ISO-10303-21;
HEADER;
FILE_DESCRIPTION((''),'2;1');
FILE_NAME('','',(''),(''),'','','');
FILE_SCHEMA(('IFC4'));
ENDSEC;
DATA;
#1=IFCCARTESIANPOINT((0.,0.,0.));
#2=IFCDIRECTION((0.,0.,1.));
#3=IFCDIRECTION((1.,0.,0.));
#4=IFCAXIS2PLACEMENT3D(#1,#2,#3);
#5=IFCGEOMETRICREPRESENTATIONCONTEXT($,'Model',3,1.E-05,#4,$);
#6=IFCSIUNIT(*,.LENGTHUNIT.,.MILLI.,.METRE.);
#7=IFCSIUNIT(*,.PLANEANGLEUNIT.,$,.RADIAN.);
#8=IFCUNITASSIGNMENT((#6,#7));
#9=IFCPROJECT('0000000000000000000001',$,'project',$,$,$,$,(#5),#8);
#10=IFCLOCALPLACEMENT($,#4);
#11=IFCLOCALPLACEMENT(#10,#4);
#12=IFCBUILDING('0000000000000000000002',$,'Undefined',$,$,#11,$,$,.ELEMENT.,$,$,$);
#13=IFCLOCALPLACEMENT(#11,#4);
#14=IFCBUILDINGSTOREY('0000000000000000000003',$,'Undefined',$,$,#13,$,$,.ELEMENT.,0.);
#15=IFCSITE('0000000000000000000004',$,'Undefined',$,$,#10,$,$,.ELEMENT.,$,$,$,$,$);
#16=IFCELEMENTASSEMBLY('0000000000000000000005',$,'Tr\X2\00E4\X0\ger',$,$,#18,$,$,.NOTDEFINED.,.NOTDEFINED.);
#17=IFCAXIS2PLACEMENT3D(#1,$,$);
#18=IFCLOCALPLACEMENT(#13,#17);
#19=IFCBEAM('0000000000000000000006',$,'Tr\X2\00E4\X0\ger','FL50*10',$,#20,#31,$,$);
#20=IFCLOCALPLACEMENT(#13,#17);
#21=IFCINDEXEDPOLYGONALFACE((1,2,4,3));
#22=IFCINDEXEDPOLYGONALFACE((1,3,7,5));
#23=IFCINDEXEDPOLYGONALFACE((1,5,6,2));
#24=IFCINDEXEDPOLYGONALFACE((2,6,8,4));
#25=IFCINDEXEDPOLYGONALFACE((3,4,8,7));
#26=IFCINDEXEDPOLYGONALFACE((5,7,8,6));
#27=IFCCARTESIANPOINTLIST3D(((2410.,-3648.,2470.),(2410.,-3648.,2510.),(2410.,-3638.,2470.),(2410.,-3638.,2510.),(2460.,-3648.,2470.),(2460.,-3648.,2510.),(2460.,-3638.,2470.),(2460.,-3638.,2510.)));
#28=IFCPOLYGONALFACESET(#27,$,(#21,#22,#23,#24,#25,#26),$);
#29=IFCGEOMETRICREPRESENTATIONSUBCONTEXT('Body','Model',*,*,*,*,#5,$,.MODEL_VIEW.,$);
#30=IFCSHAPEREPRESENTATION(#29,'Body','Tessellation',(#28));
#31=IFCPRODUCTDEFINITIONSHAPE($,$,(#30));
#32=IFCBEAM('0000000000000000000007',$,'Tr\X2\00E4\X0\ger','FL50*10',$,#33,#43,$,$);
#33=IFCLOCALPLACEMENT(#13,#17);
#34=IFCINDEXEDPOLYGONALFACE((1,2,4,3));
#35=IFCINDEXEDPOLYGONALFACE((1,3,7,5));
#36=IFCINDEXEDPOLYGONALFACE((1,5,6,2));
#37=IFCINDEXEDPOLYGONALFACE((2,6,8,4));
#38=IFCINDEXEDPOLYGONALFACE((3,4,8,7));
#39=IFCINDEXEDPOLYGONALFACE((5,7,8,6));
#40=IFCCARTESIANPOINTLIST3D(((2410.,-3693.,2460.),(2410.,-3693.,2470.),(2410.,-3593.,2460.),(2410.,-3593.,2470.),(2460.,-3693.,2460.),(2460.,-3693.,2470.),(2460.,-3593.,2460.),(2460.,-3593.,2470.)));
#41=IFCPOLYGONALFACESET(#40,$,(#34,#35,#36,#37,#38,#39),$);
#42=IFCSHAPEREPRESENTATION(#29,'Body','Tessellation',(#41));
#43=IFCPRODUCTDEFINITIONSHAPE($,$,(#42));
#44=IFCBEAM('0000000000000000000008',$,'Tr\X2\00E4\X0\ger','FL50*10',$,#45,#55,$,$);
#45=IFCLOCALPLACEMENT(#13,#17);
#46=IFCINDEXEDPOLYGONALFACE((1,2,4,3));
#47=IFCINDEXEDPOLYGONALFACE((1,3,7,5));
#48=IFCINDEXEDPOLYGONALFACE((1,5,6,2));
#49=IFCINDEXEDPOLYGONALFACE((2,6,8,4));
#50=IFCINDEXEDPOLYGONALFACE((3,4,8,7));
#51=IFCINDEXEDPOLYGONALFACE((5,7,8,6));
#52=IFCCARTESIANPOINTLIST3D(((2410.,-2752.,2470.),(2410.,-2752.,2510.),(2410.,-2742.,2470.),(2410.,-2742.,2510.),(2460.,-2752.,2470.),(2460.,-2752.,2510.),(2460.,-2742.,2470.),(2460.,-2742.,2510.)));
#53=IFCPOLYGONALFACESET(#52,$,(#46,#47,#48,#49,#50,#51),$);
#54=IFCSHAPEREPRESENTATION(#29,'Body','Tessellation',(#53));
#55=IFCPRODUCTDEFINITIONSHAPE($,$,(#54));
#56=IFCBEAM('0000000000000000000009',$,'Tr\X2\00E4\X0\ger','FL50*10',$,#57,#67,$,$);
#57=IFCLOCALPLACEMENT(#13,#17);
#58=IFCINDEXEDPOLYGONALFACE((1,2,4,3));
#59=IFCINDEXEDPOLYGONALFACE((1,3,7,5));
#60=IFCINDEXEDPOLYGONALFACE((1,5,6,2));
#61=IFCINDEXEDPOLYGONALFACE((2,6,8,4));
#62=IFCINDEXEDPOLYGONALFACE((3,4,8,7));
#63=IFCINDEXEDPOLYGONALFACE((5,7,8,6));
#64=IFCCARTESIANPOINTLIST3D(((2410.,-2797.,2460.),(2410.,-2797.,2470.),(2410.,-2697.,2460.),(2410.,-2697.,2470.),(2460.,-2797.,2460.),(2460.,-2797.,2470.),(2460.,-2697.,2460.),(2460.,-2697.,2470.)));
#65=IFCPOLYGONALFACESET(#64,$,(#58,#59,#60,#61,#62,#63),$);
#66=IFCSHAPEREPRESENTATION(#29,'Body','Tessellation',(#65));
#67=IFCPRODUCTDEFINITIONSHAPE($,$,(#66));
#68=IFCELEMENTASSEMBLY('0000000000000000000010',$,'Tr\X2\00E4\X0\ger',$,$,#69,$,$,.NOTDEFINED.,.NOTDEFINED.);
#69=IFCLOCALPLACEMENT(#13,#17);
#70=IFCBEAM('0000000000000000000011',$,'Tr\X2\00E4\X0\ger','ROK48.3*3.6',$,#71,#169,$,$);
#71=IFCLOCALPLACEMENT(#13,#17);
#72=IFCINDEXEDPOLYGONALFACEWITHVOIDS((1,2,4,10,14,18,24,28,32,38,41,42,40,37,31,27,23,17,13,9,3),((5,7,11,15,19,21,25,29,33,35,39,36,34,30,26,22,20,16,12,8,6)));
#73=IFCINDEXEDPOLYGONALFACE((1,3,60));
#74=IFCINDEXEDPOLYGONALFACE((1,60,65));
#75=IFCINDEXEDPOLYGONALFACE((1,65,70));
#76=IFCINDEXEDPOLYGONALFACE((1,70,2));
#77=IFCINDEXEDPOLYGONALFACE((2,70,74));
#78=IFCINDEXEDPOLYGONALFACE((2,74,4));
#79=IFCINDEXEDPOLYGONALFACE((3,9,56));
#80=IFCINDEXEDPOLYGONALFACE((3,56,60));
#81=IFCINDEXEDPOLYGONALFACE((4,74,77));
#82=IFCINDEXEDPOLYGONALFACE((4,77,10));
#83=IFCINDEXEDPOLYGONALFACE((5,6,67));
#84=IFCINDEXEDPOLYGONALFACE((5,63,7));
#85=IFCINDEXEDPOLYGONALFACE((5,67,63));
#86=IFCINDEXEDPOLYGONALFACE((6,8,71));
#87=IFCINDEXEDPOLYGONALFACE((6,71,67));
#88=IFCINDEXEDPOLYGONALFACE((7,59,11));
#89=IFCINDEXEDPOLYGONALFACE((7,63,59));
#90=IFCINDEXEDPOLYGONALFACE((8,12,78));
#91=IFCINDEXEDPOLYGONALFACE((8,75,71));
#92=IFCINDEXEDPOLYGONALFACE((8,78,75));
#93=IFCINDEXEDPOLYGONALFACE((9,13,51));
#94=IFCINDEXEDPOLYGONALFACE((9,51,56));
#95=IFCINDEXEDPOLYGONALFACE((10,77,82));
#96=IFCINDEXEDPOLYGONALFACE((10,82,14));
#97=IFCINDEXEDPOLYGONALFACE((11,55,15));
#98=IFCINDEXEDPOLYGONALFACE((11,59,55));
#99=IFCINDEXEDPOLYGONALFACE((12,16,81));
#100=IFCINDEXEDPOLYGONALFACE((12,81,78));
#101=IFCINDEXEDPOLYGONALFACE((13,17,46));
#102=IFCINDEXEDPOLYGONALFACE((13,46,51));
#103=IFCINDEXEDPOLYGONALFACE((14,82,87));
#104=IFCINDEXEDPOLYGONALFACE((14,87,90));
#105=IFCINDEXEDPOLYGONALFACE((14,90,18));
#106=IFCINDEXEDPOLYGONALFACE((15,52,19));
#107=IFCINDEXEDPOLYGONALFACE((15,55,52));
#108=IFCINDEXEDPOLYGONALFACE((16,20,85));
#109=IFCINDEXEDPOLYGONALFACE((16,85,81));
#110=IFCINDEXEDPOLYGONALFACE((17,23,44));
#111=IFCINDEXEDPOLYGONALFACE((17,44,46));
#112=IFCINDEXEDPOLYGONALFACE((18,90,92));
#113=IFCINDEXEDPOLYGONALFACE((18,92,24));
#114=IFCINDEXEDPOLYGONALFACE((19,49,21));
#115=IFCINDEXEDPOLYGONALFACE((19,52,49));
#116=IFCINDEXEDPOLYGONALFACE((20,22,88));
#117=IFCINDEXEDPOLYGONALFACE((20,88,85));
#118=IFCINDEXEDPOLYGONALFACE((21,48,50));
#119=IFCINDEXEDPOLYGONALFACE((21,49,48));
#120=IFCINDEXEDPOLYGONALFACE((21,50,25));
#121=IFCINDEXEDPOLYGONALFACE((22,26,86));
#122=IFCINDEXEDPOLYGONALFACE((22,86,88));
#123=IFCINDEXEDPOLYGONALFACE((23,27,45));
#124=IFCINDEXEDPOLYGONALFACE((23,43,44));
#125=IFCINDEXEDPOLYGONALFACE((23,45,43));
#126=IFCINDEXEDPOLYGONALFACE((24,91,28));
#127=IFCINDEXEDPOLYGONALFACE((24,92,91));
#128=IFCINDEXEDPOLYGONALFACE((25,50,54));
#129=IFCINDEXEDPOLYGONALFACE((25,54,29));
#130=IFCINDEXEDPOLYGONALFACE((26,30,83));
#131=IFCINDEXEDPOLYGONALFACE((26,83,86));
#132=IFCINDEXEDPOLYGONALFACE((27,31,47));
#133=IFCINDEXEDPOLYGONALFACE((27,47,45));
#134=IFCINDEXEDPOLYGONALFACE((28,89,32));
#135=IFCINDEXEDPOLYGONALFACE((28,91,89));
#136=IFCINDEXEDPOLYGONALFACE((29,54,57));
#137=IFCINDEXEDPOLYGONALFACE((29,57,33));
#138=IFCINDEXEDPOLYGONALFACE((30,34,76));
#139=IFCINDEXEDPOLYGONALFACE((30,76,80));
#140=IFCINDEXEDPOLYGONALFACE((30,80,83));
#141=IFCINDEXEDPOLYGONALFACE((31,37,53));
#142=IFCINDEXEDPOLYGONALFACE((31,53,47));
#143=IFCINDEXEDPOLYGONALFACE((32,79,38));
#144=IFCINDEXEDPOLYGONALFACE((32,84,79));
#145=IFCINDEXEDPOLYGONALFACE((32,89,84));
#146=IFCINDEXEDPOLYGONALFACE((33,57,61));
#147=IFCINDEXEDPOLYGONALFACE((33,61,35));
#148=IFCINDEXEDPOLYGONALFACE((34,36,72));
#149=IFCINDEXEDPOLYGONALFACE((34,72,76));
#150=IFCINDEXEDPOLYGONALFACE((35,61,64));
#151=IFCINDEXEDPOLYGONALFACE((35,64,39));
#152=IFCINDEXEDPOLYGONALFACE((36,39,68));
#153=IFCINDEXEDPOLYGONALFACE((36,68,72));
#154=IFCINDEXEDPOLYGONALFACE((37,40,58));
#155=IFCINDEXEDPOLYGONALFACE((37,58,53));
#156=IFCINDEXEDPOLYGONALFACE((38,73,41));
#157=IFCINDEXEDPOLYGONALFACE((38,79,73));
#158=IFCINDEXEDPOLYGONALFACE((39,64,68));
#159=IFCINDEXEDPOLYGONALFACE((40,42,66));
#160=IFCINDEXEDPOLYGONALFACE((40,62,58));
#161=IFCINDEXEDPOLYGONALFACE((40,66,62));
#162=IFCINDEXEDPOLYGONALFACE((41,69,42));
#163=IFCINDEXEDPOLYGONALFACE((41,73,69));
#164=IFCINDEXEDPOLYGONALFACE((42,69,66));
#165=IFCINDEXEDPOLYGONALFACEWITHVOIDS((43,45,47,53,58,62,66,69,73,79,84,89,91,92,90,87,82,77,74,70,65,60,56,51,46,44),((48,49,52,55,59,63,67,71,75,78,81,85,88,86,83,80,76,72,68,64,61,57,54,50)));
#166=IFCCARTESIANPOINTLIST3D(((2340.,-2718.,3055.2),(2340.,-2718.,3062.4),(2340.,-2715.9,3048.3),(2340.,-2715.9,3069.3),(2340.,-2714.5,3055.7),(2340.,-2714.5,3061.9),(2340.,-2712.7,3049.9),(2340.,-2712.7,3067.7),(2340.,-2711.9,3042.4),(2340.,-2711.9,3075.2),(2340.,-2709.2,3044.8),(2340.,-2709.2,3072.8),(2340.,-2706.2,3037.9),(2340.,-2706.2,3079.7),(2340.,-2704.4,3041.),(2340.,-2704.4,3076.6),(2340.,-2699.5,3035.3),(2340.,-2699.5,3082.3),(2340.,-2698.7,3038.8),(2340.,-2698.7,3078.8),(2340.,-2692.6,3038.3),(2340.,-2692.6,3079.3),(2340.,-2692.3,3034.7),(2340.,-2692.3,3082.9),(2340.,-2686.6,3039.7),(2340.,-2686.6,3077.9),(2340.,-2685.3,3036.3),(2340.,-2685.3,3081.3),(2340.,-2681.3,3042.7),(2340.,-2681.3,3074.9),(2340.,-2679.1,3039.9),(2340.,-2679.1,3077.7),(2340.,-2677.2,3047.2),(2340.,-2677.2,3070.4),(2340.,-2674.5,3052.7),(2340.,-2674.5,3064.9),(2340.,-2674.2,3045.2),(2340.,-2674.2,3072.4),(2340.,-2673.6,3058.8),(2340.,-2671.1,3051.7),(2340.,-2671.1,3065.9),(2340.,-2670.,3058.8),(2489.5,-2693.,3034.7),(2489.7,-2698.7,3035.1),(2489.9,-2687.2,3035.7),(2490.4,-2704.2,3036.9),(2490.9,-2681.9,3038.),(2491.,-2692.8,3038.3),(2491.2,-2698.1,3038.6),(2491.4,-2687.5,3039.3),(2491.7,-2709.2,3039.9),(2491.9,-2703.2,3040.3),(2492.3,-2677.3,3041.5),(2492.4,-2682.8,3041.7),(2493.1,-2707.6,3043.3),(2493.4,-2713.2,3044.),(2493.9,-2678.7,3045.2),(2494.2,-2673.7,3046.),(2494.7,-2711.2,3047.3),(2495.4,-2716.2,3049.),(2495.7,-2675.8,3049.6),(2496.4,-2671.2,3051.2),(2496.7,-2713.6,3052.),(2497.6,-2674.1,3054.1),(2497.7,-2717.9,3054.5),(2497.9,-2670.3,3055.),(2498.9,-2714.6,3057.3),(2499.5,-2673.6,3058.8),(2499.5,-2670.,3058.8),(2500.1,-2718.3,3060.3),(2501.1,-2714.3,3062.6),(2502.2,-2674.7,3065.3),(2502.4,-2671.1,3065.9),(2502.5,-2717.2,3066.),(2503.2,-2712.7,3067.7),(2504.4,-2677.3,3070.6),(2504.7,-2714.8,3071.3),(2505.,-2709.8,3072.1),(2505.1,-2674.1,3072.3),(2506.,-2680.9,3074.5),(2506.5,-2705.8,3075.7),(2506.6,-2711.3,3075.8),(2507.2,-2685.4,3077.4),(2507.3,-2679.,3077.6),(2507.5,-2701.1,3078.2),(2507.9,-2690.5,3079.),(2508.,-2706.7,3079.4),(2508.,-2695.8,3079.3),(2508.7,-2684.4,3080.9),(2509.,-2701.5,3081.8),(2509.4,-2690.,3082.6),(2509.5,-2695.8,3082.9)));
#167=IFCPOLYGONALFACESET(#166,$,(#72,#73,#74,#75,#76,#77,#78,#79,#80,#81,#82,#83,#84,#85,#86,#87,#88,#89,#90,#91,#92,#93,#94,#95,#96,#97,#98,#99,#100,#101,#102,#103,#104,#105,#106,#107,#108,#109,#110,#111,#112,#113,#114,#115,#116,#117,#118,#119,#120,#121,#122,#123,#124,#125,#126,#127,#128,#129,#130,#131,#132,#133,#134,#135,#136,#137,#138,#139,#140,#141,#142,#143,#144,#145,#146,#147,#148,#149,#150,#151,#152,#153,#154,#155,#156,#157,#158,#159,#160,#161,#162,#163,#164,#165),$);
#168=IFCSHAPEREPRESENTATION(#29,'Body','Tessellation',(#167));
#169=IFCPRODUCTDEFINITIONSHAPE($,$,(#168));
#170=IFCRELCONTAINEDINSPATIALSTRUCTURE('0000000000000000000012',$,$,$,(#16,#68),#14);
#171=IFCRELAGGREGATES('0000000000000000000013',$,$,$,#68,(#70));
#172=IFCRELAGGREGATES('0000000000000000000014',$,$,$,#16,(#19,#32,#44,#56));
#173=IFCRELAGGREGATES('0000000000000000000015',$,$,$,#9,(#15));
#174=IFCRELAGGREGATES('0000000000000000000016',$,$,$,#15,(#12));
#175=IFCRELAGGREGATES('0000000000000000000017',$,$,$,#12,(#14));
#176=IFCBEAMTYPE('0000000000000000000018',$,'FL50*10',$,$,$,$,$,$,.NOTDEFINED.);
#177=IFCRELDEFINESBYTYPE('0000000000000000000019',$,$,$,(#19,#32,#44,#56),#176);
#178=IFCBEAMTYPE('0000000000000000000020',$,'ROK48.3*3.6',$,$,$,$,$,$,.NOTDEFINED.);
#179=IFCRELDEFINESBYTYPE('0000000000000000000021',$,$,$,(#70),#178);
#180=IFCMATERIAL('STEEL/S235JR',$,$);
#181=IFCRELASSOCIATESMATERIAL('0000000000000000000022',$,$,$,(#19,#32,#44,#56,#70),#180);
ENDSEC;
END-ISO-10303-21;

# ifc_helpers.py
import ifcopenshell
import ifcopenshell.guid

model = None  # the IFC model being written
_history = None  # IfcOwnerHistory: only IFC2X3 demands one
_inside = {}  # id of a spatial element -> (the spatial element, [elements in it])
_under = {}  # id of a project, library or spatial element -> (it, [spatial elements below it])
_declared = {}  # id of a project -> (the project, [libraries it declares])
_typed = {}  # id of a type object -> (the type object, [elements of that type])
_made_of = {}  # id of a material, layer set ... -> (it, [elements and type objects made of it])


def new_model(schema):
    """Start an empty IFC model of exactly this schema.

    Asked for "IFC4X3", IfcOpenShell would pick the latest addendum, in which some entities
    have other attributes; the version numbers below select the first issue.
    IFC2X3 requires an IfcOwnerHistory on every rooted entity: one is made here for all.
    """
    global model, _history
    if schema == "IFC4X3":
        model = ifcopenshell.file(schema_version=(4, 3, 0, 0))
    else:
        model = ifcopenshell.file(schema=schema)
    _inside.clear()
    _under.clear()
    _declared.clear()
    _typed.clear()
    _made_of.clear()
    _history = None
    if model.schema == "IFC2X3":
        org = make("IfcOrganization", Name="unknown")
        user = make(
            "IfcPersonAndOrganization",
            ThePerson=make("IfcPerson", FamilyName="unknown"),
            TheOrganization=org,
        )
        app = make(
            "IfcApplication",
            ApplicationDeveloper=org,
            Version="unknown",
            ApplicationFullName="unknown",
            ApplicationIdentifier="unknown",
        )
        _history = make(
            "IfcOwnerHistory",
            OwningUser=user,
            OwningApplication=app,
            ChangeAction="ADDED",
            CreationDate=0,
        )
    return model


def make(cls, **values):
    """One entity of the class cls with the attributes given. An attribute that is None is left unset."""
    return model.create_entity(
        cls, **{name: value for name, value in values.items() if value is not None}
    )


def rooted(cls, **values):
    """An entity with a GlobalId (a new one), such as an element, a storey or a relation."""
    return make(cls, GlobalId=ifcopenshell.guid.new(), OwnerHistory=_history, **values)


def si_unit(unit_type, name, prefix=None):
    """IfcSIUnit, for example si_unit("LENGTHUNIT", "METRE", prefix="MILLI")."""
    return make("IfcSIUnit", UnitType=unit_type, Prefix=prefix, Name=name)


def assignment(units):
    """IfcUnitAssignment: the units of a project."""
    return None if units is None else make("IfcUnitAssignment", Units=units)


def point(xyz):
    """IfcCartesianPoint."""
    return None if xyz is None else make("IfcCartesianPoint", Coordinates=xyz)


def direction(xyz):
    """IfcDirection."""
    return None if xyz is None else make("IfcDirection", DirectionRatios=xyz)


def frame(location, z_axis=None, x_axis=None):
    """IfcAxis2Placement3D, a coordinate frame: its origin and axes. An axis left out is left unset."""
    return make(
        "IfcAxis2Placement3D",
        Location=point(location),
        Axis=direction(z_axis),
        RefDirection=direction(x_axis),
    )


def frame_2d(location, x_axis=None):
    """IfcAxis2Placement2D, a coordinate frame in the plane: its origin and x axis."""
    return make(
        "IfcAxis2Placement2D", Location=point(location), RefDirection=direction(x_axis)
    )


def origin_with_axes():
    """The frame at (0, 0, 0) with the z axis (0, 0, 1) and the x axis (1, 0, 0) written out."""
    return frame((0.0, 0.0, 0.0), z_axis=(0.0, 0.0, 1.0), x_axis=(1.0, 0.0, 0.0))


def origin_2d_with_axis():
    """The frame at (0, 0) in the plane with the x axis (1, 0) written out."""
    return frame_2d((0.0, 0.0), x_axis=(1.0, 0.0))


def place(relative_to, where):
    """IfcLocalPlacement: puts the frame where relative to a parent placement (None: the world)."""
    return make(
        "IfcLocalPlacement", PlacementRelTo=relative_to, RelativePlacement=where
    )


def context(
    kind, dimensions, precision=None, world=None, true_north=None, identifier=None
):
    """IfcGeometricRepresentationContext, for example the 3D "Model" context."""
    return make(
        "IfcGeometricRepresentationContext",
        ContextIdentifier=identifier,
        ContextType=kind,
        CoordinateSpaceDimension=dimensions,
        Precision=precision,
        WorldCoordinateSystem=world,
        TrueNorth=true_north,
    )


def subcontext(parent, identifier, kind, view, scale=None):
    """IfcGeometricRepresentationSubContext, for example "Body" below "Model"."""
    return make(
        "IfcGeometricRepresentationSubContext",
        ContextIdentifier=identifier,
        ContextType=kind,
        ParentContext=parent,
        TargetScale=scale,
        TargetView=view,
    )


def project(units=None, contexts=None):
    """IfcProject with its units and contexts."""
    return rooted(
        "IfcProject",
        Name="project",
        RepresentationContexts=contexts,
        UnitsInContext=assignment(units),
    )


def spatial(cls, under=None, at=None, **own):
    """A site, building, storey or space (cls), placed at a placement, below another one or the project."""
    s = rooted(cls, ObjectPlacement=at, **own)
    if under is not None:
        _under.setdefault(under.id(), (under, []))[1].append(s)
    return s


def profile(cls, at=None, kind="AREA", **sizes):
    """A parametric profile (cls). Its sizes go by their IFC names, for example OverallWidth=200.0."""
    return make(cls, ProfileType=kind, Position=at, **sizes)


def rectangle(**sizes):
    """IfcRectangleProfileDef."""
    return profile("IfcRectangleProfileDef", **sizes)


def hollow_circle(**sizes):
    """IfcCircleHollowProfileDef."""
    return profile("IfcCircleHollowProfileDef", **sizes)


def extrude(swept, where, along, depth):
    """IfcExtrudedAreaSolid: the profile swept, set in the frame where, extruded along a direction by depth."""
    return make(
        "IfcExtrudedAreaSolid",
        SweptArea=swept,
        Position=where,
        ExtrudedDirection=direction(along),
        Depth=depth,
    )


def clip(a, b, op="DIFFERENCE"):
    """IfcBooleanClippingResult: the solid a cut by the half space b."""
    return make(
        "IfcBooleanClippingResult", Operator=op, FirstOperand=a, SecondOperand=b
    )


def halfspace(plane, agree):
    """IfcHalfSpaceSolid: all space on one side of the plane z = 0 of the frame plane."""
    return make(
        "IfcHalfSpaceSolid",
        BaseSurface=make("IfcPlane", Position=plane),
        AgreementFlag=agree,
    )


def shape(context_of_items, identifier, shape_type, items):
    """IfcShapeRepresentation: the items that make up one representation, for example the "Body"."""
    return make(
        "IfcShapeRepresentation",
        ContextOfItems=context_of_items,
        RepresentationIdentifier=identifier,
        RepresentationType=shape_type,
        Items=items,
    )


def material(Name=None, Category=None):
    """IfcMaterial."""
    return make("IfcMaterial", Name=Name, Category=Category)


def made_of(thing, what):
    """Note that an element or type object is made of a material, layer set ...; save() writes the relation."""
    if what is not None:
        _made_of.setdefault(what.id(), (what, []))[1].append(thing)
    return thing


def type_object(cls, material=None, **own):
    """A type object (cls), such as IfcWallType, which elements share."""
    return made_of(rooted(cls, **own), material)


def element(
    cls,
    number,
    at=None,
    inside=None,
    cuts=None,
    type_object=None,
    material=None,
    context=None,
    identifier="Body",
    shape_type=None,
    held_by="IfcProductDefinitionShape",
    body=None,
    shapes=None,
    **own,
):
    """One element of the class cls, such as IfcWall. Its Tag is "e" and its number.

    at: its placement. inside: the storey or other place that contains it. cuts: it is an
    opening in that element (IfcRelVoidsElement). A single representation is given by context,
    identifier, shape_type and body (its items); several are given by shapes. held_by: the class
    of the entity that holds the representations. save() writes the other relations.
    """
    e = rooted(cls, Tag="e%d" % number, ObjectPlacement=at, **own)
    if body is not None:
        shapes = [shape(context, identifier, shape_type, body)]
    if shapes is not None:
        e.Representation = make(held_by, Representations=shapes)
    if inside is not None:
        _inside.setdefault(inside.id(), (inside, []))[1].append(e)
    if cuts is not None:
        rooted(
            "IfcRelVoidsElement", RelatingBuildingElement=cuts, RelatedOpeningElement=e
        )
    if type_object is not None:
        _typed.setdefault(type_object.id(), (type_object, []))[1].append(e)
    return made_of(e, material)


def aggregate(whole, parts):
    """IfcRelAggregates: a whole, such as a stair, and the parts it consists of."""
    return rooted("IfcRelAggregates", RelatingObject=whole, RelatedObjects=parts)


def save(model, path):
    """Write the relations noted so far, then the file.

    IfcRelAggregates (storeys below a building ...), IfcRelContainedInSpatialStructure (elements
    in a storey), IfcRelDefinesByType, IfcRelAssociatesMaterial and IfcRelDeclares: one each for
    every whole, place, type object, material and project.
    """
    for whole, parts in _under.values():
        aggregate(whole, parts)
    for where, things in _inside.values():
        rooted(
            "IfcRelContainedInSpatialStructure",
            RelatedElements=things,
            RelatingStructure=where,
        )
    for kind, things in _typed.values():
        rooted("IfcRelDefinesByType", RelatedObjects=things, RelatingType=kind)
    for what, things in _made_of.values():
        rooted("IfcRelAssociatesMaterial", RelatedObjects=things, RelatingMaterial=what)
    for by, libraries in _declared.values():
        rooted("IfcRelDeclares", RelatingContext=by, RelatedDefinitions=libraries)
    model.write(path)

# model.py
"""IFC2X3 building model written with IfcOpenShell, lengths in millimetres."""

from ifc_helpers import new_model, si_unit, frame, origin_with_axes, origin_2d_with_axis, place, context, subcontext, project, spatial, rectangle, hollow_circle, extrude, clip, halfspace, material, type_object, element, aggregate, save


model = new_model("IFC2X3")

# Units and contexts
model_context = context("Model", 3, precision=1e-05, world=origin_with_axes())
body_context = subcontext(model_context, "Body", "Model", "MODEL_VIEW")
ifc_project = project(units=[si_unit("LENGTHUNIT", "METRE", prefix="MILLI"), si_unit("PLANEANGLEUNIT", "RADIAN")], contexts=[model_context])

# Site, building, storey
site_placement = place(None, origin_with_axes())
site = spatial("IfcSite", under=ifc_project, at=site_placement, Name="Undefined", CompositionType="ELEMENT")
building_placement = place(site_placement, origin_with_axes())
building = spatial("IfcBuilding", under=site, at=building_placement, Name="Undefined", CompositionType="ELEMENT")
storey_placement = place(building_placement, origin_with_axes())
storey = spatial("IfcBuildingStorey", under=building, at=storey_placement, Name="Undefined", CompositionType="ELEMENT", Elevation=0.0)

# Element assembly, beams
assembly_1_placement = place(storey_placement, origin_with_axes())
assembly_1 = element("IfcElementAssembly", 1, at=assembly_1_placement, inside=storey, Name="Träger", AssemblyPlace="NOTDEFINED", PredefinedType="NOTDEFINED")
ifc_material = material(Name="STEEL/S235JR")
beam_type_1 = type_object("IfcBeamType", Name="FL50*10", PredefinedType="NOTDEFINED")
beam_1_placement = place(assembly_1_placement, frame((2435.0, -3643.0, 2470.0), z_axis=(-1.0, 0.0, 0.0), x_axis=(0.0, 0.0, 1.0)))
beam_1 = element("IfcBeam", 2, at=beam_1_placement, type_object=beam_type_1, material=ifc_material, Name="Träger", Description="FL50*10", context=body_context, shape_type="SweptSolid", body=[
    extrude(rectangle(XDim=10.0, YDim=50.0, at=origin_2d_with_axis()), frame((40.0, 0.0, 0.0), z_axis=(-1.0, 0.0, 0.0), x_axis=(0.0, -1.0, 0.0)), (0.0, 0.0, 1.0), 40.0),
])
beam_2_placement = place(assembly_1_placement, frame((2435.0, -3593.0, 2465.0), z_axis=(-1.0, 0.0, 0.0), x_axis=(0.0, -1.0, 0.0)))
beam_2 = element("IfcBeam", 3, at=beam_2_placement, type_object=beam_type_1, material=ifc_material, Name="Träger", Description="FL50*10", context=body_context, shape_type="SweptSolid", body=[
    extrude(rectangle(XDim=10.0, YDim=50.0, at=origin_2d_with_axis()), frame((100.0, 0.0, 0.0), z_axis=(-1.0, 0.0, 0.0), x_axis=(0.0, -1.0, 0.0)), (0.0, 0.0, 1.0), 100.0),
])
beam_3_placement = place(assembly_1_placement, frame((2435.0, -2747.0, 2470.0), z_axis=(-1.0, 0.0, 0.0), x_axis=(0.0, 0.0, 1.0)))
beam_3 = element("IfcBeam", 4, at=beam_3_placement, type_object=beam_type_1, material=ifc_material, Name="Träger", Description="FL50*10", context=body_context, shape_type="SweptSolid", body=[
    extrude(rectangle(XDim=10.0, YDim=50.0, at=origin_2d_with_axis()), frame((40.0, 0.0, 0.0), z_axis=(-1.0, 0.0, 0.0), x_axis=(0.0, -1.0, 0.0)), (0.0, 0.0, 1.0), 40.0),
])
beam_4_placement = place(assembly_1_placement, frame((2435.0, -2697.0, 2465.0), z_axis=(-1.0, 0.0, 0.0), x_axis=(0.0, -1.0, 0.0)))
beam_4 = element("IfcBeam", 5, at=beam_4_placement, type_object=beam_type_1, material=ifc_material, Name="Träger", Description="FL50*10", context=body_context, shape_type="SweptSolid", body=[
    extrude(rectangle(XDim=10.0, YDim=50.0, at=origin_2d_with_axis()), frame((100.0, 0.0, 0.0), z_axis=(-1.0, 0.0, 0.0), x_axis=(0.0, -1.0, 0.0)), (0.0, 0.0, 1.0), 100.0),
])

# Element assembly, beam
assembly_2_placement = place(storey_placement, origin_with_axes())
assembly_2 = element("IfcElementAssembly", 6, at=assembly_2_placement, inside=storey, Name="Träger", AssemblyPlace="NOTDEFINED", PredefinedType="NOTDEFINED")
beam_type_2 = type_object("IfcBeamType", Name="ROK48.3*3.6", PredefinedType="NOTDEFINED")
beam_5_placement = place(assembly_2_placement, frame((2500.0, -2694.1, 3058.8), z_axis=(0.0, 0.0, 1.0), x_axis=(-1.0, 0.0, 0.0)))
beam_5 = element("IfcBeam", 7, at=beam_5_placement, type_object=beam_type_2, material=ifc_material, Name="Träger", Description="ROK48.3*3.6", context=body_context, shape_type="Clipping", body=[
    clip(extrude(hollow_circle(Radius=24.1, WallThickness=3.6, at=origin_2d_with_axis()), frame((160.0, 0.0, 0.0), z_axis=(-1.0, 0.0, 0.0), x_axis=(0.0, -1.0, 0.0)), (0.0, 0.0, 1.0), 169.6), halfspace(frame((-9.5, 0.0, 24.2), z_axis=(-0.923878, 0.0, -0.382686), x_axis=(0.0, -1.0, 0.0)), False)),
])
aggregate(assembly_2, [beam_5])

aggregate(assembly_1, [beam_1, beam_2, beam_3, beam_4])

save(model, "model.ifc")
